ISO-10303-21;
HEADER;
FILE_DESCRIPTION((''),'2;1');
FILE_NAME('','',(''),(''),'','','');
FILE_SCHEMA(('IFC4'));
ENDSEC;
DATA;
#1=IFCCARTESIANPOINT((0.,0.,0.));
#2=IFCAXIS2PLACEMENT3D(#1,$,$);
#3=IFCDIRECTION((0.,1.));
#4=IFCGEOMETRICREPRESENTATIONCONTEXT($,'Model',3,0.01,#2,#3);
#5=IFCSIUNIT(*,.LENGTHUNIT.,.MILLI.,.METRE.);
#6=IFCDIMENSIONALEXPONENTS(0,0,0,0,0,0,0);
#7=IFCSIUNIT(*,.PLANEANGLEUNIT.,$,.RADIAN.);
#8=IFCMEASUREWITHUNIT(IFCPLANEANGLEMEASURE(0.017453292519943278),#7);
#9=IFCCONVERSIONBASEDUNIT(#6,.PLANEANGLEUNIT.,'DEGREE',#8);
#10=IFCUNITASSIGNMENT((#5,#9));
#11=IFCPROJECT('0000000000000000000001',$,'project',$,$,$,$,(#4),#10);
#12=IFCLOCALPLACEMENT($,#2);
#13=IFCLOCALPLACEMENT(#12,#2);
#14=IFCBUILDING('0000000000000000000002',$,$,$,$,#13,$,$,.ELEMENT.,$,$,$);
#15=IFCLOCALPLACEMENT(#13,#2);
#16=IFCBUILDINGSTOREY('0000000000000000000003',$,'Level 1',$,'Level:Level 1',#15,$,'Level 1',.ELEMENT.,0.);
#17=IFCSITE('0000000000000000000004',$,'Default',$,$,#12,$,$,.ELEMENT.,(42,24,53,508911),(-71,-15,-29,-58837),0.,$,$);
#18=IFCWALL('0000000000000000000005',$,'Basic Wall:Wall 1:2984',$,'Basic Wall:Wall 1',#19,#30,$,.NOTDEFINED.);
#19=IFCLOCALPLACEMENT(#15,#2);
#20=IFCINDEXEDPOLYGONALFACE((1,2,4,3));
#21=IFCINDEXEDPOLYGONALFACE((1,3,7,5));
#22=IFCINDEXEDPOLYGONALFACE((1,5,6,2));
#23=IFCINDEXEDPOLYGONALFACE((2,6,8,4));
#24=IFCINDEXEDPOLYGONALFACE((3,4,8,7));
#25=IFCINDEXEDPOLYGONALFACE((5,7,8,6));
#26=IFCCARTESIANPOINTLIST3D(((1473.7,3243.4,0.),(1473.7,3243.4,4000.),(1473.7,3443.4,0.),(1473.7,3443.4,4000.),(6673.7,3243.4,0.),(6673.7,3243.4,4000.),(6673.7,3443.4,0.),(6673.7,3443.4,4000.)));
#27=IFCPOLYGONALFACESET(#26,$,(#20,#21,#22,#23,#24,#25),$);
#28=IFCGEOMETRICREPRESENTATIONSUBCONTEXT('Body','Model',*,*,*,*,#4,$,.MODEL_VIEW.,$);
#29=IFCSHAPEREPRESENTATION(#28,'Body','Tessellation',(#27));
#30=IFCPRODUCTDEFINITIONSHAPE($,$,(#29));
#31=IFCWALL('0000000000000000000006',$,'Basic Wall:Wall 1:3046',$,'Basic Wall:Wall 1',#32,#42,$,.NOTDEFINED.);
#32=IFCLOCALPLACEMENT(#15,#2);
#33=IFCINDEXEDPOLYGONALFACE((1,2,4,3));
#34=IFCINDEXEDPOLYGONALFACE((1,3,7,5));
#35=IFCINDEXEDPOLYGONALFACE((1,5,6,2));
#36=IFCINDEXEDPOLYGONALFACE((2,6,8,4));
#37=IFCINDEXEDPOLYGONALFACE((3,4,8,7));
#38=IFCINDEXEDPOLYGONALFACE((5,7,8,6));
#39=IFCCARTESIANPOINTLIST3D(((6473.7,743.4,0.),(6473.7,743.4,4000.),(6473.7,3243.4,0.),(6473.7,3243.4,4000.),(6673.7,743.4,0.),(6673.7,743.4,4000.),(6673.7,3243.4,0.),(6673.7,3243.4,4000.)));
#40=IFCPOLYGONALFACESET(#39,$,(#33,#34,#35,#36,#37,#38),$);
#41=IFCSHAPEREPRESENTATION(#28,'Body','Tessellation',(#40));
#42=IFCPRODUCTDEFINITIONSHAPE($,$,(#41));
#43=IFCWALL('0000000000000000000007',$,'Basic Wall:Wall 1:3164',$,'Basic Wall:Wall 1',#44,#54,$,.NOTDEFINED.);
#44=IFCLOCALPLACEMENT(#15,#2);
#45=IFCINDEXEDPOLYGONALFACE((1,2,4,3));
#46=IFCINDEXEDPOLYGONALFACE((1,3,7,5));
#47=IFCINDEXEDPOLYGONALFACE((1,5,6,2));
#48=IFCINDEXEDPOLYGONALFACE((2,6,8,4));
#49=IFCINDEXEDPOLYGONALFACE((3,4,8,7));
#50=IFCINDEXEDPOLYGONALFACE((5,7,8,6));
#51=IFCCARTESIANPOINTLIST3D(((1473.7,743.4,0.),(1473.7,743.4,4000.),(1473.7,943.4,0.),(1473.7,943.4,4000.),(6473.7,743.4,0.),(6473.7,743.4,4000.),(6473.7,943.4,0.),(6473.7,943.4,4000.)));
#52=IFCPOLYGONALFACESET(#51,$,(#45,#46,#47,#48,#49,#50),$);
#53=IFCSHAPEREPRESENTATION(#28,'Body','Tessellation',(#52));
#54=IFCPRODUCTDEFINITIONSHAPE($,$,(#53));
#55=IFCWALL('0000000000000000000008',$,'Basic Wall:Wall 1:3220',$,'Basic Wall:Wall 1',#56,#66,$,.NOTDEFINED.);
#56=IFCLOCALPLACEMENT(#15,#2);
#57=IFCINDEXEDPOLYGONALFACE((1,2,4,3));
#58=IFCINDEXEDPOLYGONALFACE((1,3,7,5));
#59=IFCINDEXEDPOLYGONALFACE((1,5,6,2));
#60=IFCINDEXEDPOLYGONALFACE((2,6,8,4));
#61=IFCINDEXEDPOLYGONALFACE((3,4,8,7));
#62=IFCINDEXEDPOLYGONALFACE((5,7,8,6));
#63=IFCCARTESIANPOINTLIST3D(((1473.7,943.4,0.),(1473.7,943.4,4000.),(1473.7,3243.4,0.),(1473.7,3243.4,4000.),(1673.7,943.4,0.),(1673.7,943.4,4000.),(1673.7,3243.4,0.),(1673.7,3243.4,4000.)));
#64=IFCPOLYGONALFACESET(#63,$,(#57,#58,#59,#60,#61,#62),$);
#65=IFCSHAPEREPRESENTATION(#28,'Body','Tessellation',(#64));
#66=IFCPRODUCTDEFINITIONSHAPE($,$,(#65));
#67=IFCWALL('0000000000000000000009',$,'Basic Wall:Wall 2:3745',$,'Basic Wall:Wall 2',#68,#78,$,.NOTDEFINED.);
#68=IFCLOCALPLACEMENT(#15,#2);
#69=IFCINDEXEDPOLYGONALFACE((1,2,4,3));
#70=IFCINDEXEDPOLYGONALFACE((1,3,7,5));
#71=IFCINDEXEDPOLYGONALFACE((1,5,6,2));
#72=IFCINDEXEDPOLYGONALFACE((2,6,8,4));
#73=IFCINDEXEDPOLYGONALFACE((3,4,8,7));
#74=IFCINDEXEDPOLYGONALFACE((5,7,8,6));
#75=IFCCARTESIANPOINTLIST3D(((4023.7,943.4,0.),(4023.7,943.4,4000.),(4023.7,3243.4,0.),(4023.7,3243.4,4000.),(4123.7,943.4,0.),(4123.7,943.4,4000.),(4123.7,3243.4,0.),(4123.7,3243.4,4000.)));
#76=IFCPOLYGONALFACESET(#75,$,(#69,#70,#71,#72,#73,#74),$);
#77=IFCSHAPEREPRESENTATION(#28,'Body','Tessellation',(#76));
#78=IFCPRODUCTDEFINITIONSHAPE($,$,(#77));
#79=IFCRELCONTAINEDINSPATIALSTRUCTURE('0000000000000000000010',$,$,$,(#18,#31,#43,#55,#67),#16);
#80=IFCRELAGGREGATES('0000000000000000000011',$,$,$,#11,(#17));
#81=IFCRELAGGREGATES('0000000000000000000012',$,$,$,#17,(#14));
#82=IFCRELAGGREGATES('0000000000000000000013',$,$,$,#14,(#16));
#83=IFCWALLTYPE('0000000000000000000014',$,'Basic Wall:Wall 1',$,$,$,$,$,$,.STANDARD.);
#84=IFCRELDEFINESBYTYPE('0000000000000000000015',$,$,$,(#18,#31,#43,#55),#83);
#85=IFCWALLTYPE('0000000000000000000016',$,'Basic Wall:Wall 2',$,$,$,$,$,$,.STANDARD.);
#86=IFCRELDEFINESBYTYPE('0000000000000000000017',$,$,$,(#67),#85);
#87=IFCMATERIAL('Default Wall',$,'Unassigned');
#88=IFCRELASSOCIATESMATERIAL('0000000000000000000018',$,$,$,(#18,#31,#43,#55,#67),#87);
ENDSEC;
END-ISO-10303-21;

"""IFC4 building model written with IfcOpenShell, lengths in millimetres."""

from ifc_helpers import new_model, entity, si_unit, converted_unit, direction, frame, origin, place, context, subcontext, project, spatial, indexed_curve, outline, extrude, material, type_object, element, save


model = new_model("IFC4")

# Units and contexts
model_context = context("Model", 3, precision=0.01, world=origin(), true_north=direction((0.0, 1.0)))
body_context = subcontext(model_context, "Body", "Model", "MODEL_VIEW")
ifc_project = project(units=[si_unit("LENGTHUNIT", "METRE", prefix="MILLI"), converted_unit("PLANEANGLEUNIT", "DEGREE", entity("IfcPlaneAngleMeasure", 0.017453292519943278), si_unit("PLANEANGLEUNIT", "RADIAN"), dimensions=[0, 0, 0, 0, 0, 0, 0])], contexts=[model_context])

# Site, building, storey
site_placement = place(None, origin())
site = spatial("IfcSite", under=ifc_project, at=site_placement, Name="Default", CompositionType="ELEMENT", RefLatitude=(42, 24, 53, 508911), RefLongitude=(-71, -15, -29, -58837), RefElevation=0.0)
building_placement = place(site_placement, origin())
building = spatial("IfcBuilding", under=site, at=building_placement, CompositionType="ELEMENT")
storey_placement = place(building_placement, origin())
storey = spatial("IfcBuildingStorey", under=building, at=storey_placement, Name="Level 1", ObjectType="Level:Level 1", LongName="Level 1", CompositionType="ELEMENT", Elevation=0.0)

# Walls
ifc_material = material(Name="Default Wall", Category="Unassigned")
wall_type_1 = type_object("IfcWallType", Name="Basic Wall:Wall 1", PredefinedType="STANDARD")
wall_1_placement = place(storey_placement, frame((1473.7, 3343.4, 0.0)))
element("IfcWall", 1, at=wall_1_placement, inside=storey, type_object=wall_type_1, material=ifc_material, Name="Basic Wall:Wall 1:2984", ObjectType="Basic Wall:Wall 1", PredefinedType="NOTDEFINED", context=body_context, shape_type="SweptSolid", body=[
    extrude(outline(indexed_curve([(5200.0, 100.0), (0.0, 100.0), (0.0, -100.0), (5200.0, -100.0), (5200.0, 100.0)], self_intersect=False)), origin(), (0.0, 0.0, 1.0), 4000.0),
])
wall_2_placement = place(storey_placement, frame((6573.7, 3243.4, 0.0), z_axis=(0.0, 0.0, 1.0), x_axis=(0.0, -1.0, 0.0)))
element("IfcWall", 2, at=wall_2_placement, inside=storey, type_object=wall_type_1, material=ifc_material, Name="Basic Wall:Wall 1:3046", ObjectType="Basic Wall:Wall 1", PredefinedType="NOTDEFINED", context=body_context, shape_type="SweptSolid", body=[
    extrude(outline(indexed_curve([(2500.0, 100.0), (0.0, 100.0), (0.0, -100.0), (2500.0, -100.0), (2500.0, 100.0)], self_intersect=False)), origin(), (0.0, 0.0, 1.0), 4000.0),
])
wall_3_placement = place(storey_placement, frame((6473.7, 843.4, 0.0), z_axis=(0.0, 0.0, 1.0), x_axis=(-1.0, 0.0, 0.0)))
element("IfcWall", 3, at=wall_3_placement, inside=storey, type_object=wall_type_1, material=ifc_material, Name="Basic Wall:Wall 1:3164", ObjectType="Basic Wall:Wall 1", PredefinedType="NOTDEFINED", context=body_context, shape_type="SweptSolid", body=[
    extrude(outline(indexed_curve([(5000.0, 100.0), (0.0, 100.0), (0.0, -100.0), (5000.0, -100.0), (5000.0, 100.0)], self_intersect=False)), origin(), (0.0, 0.0, 1.0), 4000.0),
])
wall_4_placement = place(storey_placement, frame((1573.7, 943.4, 0.0), z_axis=(0.0, 0.0, 1.0), x_axis=(0.0, 1.0, 0.0)))
element("IfcWall", 4, at=wall_4_placement, inside=storey, type_object=wall_type_1, material=ifc_material, Name="Basic Wall:Wall 1:3220", ObjectType="Basic Wall:Wall 1", PredefinedType="NOTDEFINED", context=body_context, shape_type="SweptSolid", body=[
    extrude(outline(indexed_curve([(2300.0, 100.0), (0.0, 100.0), (0.0, -100.0), (2300.0, -100.0), (2300.0, 100.0)], self_intersect=False)), origin(), (0.0, 0.0, 1.0), 4000.0),
])
wall_type_2 = type_object("IfcWallType", Name="Basic Wall:Wall 2", PredefinedType="STANDARD")
wall_5_placement = place(storey_placement, frame((4073.7, 3243.4, 0.0), z_axis=(0.0, 0.0, 1.0), x_axis=(0.0, -1.0, 0.0)))
element("IfcWall", 5, at=wall_5_placement, inside=storey, type_object=wall_type_2, material=ifc_material, Name="Basic Wall:Wall 2:3745", ObjectType="Basic Wall:Wall 2", PredefinedType="NOTDEFINED", context=body_context, shape_type="SweptSolid", body=[
    extrude(outline(indexed_curve([(2300.0, 50.0), (0.0, 50.0), (0.0, -50.0), (2300.0, -50.0), (2300.0, 50.0)], self_intersect=False)), origin(), (0.0, 0.0, 1.0), 4000.0),
])

save(model, "model.ifc")
